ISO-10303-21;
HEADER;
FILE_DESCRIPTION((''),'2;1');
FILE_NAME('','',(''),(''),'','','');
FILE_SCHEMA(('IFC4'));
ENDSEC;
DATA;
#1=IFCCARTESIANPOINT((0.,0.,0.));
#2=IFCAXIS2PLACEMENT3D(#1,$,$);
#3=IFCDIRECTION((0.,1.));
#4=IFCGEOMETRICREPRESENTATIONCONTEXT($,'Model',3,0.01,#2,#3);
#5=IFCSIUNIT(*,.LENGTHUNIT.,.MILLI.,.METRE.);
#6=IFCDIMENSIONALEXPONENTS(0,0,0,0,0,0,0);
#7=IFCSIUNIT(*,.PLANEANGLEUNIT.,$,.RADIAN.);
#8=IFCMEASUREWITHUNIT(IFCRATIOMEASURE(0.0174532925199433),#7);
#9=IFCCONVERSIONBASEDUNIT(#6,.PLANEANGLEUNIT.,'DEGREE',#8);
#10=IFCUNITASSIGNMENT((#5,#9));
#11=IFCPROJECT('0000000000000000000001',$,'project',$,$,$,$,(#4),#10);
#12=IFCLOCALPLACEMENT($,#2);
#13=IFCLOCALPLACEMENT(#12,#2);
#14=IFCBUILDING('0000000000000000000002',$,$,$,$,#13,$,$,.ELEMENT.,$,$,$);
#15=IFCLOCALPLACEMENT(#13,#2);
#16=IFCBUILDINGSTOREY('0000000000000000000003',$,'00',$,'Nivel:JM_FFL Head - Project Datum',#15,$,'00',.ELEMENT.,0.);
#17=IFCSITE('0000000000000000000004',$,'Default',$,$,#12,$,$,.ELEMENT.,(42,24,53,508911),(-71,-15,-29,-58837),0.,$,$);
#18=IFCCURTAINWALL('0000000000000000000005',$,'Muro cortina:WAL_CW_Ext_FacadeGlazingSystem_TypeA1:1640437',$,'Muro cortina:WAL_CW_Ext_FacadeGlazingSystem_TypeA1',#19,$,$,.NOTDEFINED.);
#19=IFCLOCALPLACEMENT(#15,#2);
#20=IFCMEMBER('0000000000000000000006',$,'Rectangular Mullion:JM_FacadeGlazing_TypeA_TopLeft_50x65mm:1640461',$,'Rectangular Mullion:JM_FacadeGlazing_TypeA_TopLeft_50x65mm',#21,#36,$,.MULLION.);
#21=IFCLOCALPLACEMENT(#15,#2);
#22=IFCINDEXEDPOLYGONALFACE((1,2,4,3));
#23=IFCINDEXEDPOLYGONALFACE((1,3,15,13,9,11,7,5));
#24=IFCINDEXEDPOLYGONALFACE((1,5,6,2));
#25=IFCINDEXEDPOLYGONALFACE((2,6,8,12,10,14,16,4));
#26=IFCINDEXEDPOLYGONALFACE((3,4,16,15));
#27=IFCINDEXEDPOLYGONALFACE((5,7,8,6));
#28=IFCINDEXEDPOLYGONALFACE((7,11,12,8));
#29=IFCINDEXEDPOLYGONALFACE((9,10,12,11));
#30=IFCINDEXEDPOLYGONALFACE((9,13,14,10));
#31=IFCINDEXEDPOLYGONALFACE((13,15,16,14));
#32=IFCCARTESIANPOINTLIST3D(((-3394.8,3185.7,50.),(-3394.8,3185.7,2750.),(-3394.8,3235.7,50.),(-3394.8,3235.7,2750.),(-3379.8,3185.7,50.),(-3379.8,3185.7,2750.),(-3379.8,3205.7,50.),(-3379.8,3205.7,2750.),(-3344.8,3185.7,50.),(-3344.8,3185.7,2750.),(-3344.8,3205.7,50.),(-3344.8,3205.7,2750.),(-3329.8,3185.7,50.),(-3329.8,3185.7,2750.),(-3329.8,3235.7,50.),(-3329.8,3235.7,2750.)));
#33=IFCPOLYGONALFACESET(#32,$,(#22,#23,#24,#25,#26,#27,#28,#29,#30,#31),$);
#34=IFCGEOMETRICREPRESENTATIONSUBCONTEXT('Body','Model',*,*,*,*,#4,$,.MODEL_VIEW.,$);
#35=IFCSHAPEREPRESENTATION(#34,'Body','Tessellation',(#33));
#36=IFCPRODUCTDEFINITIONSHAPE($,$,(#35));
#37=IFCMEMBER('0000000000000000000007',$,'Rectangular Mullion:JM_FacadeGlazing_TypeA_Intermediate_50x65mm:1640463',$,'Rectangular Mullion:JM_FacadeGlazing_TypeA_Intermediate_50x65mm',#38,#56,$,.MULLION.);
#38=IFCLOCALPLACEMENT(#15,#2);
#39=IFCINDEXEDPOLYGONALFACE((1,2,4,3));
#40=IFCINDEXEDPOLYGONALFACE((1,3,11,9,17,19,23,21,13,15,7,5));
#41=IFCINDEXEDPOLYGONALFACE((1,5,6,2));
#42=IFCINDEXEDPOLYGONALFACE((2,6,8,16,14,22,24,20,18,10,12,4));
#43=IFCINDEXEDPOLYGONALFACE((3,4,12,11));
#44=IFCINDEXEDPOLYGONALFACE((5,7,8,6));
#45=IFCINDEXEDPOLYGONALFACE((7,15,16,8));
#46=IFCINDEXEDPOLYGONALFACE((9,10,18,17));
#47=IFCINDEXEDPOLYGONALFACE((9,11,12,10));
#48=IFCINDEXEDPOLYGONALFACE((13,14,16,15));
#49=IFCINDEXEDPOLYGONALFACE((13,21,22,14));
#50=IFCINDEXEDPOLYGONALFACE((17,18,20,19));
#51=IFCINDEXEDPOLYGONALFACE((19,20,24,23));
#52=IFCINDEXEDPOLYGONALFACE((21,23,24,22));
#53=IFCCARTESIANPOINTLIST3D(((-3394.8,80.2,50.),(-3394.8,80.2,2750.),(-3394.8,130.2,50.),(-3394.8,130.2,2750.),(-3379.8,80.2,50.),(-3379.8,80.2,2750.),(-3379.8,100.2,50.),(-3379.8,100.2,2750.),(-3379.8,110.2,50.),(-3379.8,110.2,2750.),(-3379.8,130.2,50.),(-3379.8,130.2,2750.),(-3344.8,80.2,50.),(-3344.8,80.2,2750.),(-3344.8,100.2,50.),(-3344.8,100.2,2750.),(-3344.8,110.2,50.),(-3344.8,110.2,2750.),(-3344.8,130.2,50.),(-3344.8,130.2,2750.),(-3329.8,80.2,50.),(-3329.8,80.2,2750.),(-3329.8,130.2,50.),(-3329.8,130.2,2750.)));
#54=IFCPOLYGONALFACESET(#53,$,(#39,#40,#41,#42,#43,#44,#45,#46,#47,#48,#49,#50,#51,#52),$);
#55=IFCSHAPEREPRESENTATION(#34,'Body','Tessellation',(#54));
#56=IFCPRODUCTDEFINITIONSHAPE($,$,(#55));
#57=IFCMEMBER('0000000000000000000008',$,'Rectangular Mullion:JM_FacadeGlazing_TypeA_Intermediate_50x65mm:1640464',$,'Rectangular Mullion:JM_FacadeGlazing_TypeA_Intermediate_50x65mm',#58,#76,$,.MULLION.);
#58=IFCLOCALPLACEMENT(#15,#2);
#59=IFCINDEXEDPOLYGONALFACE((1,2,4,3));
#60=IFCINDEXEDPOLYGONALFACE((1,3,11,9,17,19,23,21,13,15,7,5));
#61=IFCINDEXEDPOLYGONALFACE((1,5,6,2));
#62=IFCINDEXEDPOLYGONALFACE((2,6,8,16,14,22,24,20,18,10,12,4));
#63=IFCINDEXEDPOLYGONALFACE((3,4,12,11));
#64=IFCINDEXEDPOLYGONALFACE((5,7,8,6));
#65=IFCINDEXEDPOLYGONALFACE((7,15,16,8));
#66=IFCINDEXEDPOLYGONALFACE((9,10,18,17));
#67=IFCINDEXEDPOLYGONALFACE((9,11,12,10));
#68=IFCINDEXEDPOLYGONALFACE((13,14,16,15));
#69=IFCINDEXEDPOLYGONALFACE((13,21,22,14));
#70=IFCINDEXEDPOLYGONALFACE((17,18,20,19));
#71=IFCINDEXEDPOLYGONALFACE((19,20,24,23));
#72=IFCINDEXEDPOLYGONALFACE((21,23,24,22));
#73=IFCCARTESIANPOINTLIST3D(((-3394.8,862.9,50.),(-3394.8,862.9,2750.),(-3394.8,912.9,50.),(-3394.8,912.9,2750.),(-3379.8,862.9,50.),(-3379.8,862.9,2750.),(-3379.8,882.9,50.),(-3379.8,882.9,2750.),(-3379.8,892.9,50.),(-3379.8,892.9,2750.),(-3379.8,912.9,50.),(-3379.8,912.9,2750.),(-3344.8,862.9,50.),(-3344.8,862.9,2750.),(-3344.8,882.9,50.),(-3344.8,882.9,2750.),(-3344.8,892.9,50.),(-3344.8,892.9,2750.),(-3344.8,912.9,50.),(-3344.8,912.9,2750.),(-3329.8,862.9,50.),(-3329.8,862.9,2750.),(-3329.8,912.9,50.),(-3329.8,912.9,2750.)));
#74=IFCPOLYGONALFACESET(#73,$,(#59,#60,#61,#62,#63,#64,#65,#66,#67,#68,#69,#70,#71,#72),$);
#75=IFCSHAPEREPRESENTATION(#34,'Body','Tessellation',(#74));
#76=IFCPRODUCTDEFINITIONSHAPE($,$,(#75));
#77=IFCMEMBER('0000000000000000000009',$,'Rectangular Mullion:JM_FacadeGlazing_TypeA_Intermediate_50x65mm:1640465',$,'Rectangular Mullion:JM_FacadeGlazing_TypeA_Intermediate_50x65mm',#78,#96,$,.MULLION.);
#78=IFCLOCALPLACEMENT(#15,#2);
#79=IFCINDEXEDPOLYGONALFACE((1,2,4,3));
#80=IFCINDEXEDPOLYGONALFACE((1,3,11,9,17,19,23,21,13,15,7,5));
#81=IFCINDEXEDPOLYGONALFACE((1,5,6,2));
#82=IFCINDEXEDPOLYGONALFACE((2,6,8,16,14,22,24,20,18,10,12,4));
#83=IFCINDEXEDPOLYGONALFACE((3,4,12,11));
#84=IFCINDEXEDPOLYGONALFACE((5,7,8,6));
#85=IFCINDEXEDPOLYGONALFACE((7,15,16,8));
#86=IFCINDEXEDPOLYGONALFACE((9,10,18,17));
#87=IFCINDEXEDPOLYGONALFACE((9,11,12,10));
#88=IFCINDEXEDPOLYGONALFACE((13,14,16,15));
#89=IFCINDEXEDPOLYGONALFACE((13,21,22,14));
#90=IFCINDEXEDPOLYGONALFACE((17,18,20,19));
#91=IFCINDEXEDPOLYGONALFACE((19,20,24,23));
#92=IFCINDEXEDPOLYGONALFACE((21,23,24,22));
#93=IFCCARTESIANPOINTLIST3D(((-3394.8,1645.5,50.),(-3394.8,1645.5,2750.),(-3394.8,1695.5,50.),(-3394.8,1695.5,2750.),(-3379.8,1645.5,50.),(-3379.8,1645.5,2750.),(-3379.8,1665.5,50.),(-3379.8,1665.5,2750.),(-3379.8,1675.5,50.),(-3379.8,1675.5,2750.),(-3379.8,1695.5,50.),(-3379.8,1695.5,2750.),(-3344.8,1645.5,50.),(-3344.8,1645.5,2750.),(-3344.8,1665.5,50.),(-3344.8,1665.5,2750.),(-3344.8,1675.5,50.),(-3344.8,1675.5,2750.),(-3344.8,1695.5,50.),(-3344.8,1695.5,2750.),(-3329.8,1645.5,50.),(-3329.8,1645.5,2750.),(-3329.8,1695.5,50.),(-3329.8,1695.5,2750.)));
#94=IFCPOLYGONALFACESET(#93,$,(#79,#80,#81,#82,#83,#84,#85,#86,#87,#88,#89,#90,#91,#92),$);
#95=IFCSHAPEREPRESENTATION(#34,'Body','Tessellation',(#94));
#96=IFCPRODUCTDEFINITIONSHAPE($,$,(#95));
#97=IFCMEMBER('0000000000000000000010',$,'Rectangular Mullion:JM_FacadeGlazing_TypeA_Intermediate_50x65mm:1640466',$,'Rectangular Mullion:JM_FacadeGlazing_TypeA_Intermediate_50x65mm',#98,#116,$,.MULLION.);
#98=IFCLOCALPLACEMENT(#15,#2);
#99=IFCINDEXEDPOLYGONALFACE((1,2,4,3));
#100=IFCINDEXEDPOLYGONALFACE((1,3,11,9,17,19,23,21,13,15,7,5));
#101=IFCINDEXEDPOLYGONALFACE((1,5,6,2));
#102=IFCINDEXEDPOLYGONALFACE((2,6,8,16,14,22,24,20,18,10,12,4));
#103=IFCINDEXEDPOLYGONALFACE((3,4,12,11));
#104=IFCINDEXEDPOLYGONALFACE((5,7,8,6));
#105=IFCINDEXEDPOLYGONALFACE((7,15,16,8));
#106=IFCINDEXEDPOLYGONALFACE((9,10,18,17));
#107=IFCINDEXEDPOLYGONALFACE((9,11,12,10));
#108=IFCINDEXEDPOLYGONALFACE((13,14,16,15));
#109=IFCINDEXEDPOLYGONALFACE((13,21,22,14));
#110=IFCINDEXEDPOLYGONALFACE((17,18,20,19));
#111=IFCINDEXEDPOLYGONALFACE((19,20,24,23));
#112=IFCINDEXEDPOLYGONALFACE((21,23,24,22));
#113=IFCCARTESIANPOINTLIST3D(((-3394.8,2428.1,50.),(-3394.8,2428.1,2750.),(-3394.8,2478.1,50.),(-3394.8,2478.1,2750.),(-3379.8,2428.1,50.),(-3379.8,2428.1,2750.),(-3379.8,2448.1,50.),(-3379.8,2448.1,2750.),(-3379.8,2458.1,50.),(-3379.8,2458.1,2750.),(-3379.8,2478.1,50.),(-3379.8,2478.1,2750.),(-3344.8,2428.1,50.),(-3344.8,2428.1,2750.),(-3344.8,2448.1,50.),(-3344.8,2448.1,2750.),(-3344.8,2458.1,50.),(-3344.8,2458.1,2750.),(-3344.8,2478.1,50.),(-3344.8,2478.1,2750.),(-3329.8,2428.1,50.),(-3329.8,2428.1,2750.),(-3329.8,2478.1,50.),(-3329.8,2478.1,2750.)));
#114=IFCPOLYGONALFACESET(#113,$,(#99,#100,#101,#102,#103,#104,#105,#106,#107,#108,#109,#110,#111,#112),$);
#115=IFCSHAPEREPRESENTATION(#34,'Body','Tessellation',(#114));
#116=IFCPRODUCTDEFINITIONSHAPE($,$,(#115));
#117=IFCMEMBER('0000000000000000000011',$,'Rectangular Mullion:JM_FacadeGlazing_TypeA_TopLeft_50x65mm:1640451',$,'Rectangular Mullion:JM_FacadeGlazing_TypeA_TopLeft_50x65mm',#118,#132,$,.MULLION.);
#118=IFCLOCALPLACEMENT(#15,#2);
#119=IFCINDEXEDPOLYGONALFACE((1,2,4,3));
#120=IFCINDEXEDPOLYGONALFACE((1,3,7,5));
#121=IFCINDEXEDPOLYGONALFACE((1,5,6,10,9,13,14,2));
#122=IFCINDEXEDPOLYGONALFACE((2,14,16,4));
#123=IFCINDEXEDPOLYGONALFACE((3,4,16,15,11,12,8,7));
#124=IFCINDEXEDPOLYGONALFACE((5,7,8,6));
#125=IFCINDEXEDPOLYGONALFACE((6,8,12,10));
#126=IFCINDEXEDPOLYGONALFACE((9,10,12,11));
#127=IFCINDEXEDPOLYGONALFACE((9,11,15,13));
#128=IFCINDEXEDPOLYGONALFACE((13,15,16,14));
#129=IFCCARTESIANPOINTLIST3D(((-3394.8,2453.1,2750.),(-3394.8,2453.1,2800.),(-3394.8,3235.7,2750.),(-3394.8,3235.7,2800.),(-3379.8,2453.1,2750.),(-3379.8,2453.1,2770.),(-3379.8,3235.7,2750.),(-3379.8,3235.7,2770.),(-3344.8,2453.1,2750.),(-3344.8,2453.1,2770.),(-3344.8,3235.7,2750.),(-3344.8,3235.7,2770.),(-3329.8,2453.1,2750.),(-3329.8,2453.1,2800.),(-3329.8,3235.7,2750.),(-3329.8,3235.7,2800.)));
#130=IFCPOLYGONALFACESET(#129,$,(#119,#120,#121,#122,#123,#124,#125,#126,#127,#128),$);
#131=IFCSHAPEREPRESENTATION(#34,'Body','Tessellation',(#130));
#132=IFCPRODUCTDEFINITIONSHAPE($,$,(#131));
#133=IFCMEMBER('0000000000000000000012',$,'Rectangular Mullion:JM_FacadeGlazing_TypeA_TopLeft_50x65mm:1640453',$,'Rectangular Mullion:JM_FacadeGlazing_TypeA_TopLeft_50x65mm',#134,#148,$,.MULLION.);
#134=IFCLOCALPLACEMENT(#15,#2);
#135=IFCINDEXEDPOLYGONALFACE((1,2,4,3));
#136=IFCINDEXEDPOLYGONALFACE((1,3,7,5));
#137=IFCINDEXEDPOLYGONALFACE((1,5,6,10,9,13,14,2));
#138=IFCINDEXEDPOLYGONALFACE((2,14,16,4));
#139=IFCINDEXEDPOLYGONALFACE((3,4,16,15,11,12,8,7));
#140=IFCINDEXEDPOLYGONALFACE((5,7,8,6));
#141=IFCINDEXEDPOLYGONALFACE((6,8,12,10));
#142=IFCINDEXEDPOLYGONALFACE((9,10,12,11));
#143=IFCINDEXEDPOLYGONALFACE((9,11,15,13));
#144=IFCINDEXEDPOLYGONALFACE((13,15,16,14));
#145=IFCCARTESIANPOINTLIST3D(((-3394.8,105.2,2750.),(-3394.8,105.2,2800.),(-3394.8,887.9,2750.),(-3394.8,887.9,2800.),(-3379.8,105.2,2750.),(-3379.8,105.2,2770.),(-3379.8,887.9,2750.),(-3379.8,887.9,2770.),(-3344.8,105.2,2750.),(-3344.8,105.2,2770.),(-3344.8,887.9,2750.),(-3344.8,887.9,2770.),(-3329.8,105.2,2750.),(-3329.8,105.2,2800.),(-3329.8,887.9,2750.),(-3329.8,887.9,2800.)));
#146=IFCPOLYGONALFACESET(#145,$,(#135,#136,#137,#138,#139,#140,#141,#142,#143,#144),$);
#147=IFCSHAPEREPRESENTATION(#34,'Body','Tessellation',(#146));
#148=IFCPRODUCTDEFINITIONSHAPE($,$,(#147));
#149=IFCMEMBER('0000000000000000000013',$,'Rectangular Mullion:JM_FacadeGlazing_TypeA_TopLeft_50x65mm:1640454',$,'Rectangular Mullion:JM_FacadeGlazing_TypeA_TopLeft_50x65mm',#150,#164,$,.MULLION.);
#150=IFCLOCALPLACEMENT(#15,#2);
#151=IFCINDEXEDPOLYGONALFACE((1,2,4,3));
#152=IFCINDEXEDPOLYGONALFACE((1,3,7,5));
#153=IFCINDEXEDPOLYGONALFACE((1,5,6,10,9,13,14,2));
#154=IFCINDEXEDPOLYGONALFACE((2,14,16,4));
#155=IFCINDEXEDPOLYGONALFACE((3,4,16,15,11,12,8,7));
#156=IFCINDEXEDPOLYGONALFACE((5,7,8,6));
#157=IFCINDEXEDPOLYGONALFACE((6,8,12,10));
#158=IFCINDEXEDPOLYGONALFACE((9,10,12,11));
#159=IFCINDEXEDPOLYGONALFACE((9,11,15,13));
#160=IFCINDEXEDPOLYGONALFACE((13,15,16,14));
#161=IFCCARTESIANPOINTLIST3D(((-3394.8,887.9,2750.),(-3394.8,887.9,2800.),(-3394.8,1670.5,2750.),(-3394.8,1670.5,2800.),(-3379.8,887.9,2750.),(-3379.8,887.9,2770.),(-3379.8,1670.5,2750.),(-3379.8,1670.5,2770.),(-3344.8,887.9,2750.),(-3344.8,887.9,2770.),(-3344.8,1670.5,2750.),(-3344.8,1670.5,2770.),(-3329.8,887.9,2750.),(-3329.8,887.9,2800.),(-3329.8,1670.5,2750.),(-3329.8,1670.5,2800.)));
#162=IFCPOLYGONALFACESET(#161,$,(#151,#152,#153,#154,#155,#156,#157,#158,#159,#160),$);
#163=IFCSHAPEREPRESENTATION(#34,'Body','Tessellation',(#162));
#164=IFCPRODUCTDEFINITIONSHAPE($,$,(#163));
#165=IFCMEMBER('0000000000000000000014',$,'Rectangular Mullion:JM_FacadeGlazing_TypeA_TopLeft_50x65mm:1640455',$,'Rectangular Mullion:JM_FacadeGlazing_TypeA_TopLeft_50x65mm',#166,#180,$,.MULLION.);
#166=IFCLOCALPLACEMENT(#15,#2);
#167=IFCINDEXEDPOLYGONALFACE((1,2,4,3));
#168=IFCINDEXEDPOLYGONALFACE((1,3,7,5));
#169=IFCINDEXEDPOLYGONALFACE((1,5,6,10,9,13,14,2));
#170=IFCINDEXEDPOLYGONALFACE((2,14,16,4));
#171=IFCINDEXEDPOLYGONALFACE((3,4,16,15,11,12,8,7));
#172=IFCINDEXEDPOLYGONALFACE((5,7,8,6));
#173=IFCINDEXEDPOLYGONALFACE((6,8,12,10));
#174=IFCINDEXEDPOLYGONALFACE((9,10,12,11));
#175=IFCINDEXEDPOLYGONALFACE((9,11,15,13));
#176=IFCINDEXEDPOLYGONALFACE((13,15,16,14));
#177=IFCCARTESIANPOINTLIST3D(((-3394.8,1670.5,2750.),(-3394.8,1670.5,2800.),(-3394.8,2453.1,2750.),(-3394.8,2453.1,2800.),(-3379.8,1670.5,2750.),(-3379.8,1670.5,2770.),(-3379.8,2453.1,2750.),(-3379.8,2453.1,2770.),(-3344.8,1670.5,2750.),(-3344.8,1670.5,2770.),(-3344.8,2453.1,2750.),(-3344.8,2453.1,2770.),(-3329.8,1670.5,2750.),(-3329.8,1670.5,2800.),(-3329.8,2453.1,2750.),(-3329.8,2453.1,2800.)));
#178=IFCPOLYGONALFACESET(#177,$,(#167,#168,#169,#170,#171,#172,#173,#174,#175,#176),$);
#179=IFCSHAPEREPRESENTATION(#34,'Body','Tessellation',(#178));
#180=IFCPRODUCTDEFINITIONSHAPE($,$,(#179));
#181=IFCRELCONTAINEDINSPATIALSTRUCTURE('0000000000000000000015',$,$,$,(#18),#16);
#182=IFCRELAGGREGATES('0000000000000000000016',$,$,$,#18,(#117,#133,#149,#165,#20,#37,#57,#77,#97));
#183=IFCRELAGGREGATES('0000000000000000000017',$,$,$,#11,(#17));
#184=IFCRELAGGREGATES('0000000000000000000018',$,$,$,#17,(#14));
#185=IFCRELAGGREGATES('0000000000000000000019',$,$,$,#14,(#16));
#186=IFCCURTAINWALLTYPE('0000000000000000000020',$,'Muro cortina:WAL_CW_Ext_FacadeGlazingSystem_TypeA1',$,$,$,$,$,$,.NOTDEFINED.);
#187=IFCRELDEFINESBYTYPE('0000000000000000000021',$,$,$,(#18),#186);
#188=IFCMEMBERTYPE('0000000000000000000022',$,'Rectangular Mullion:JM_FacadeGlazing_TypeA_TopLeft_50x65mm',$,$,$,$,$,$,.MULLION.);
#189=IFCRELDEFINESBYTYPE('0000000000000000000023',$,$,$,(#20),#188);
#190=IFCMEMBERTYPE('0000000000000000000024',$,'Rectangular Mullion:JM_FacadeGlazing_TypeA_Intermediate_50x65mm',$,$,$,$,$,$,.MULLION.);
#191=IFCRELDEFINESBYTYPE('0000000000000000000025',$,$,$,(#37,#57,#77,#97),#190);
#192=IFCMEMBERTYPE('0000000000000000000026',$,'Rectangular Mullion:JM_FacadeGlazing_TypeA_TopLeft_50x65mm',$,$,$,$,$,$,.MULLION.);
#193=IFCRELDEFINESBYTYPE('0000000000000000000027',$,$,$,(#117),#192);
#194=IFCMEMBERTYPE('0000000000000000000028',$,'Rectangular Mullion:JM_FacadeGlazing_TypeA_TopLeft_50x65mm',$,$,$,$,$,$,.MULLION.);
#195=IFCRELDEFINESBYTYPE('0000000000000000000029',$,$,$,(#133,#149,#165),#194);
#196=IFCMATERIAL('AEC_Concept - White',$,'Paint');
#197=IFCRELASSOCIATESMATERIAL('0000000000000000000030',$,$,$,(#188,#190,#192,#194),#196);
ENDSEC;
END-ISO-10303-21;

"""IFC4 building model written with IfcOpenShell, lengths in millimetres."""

from ifc_helpers import new_model, entity, si_unit, converted_unit, direction, frame, origin, place, context, subcontext, project, spatial, indexed_curve, outline, extrude, source, transform, mapped, material, type_object, type_shapes, element, aggregate, save


model = new_model("IFC4")

# Units and contexts
model_context = context("Model", 3, precision=0.01, world=origin(), true_north=direction((0.0, 1.0)))
body_context = subcontext(model_context, "Body", "Model", "MODEL_VIEW")
ifc_project = project(units=[si_unit("LENGTHUNIT", "METRE", prefix="MILLI"), converted_unit("PLANEANGLEUNIT", "DEGREE", entity("IfcRatioMeasure", 0.0174532925199433), si_unit("PLANEANGLEUNIT", "RADIAN"), dimensions=[0, 0, 0, 0, 0, 0, 0])], contexts=[model_context])

# Site, building, storey
site_placement = place(None, origin())
site = spatial("IfcSite", under=ifc_project, at=site_placement, Name="Default", CompositionType="ELEMENT", RefLatitude=(42, 24, 53, 508911), RefLongitude=(-71, -15, -29, -58837), RefElevation=0.0)
building_placement = place(site_placement, origin())
building = spatial("IfcBuilding", under=site, at=building_placement, CompositionType="ELEMENT")
storey_placement = place(building_placement, origin())
storey = spatial("IfcBuildingStorey", under=building, at=storey_placement, Name="00", ObjectType="Nivel:JM_FFL Head - Project Datum", LongName="00", CompositionType="ELEMENT", Elevation=0.0)

# Curtain wall, members
curtain_wall_type = type_object("IfcCurtainWallType", Name="Muro cortina:WAL_CW_Ext_FacadeGlazingSystem_TypeA1", PredefinedType="NOTDEFINED")
curtain_wall_placement = place(storey_placement, origin())
curtain_wall = element("IfcCurtainWall", 1, at=curtain_wall_placement, inside=storey, type_object=curtain_wall_type, Name="Muro cortina:WAL_CW_Ext_FacadeGlazingSystem_TypeA1:1640437", ObjectType="Muro cortina:WAL_CW_Ext_FacadeGlazingSystem_TypeA1", PredefinedType="NOTDEFINED")
ifc_material_1 = material(Name="AEC_Concept - White", Category="Paint")
member_type_1 = type_object("IfcMemberType", Name="Rectangular Mullion:JM_FacadeGlazing_TypeA_TopLeft_50x65mm", PredefinedType="MULLION", material=ifc_material_1)
shared_shape_1 = source(origin(), body_context, "Body", "SweptSolid", [
    extrude(outline(indexed_curve([(-32.5, -17.5), (-17.5, -17.5), (-17.5, 2.5), (17.5, 2.5), (17.5, -17.5), (32.5, -17.5), (32.5, 32.5), (-32.5, 32.5), (-32.5, -17.5)], self_intersect=False)), frame((-32.5, -32.5, -2700.0), z_axis=(0.0, 0.0, 1.0), x_axis=(0.0, -1.0, 0.0)), (0.0, 0.0, 1.0), 2700.0),
])
type_shapes(member_type_1, [shared_shape_1])
member_1_placement = place(curtain_wall_placement, frame((-3329.8, 3235.7, 50.0), z_axis=(0.0, 0.0, -1.0), x_axis=(0.0, 1.0, 0.0)))
member_1 = element("IfcMember", 2, at=member_1_placement, type_object=member_type_1, Name="Rectangular Mullion:JM_FacadeGlazing_TypeA_TopLeft_50x65mm:1640461", ObjectType="Rectangular Mullion:JM_FacadeGlazing_TypeA_TopLeft_50x65mm", PredefinedType="MULLION", context=body_context, shape_type="MappedRepresentation", body=[
    mapped(shared_shape_1, transform((0.0, 0.0, 0.0), scale=1.0)),
])
member_type_2 = type_object("IfcMemberType", Name="Rectangular Mullion:JM_FacadeGlazing_TypeA_Intermediate_50x65mm", PredefinedType="MULLION", material=ifc_material_1)
shared_shape_2 = source(origin(), body_context, "Body", "SweptSolid", [
    extrude(outline(indexed_curve([(-32.5, -25.0), (-17.5, -25.0), (-17.5, -5.0), (17.5, -5.0), (17.5, -25.0), (32.5, -25.0), (32.5, 25.0), (17.5, 25.0), (17.5, 5.0), (-17.5, 5.0), (-17.5, 25.0), (-32.5, 25.0), (-32.5, -25.0)], self_intersect=False)), frame((0.0, -32.5, -2700.0), z_axis=(0.0, 0.0, 1.0), x_axis=(0.0, -1.0, 0.0)), (0.0, 0.0, 1.0), 2700.0),
])
type_shapes(member_type_2, [shared_shape_2])
member_2_placement = place(curtain_wall_placement, frame((-3329.8, 105.2, 50.0), z_axis=(0.0, 0.0, -1.0), x_axis=(0.0, 1.0, 0.0)))
member_2 = element("IfcMember", 3, at=member_2_placement, type_object=member_type_2, Name="Rectangular Mullion:JM_FacadeGlazing_TypeA_Intermediate_50x65mm:1640463", ObjectType="Rectangular Mullion:JM_FacadeGlazing_TypeA_Intermediate_50x65mm", PredefinedType="MULLION", context=body_context, shape_type="MappedRepresentation", body=[
    mapped(shared_shape_2, transform((0.0, 0.0, 0.0), scale=1.0)),
])
member_3_placement = place(curtain_wall_placement, frame((-3329.8, 887.9, 50.0), z_axis=(0.0, 0.0, -1.0), x_axis=(0.0, 1.0, 0.0)))
member_3 = element("IfcMember", 4, at=member_3_placement, type_object=member_type_2, Name="Rectangular Mullion:JM_FacadeGlazing_TypeA_Intermediate_50x65mm:1640464", ObjectType="Rectangular Mullion:JM_FacadeGlazing_TypeA_Intermediate_50x65mm", PredefinedType="MULLION", context=body_context, shape_type="MappedRepresentation", body=[
    mapped(shared_shape_2, transform((0.0, 0.0, 0.0), scale=1.0)),
])
member_4_placement = place(curtain_wall_placement, frame((-3329.8, 1670.5, 50.0), z_axis=(0.0, 0.0, -1.0), x_axis=(0.0, 1.0, 0.0)))
member_4 = element("IfcMember", 5, at=member_4_placement, type_object=member_type_2, Name="Rectangular Mullion:JM_FacadeGlazing_TypeA_Intermediate_50x65mm:1640465", ObjectType="Rectangular Mullion:JM_FacadeGlazing_TypeA_Intermediate_50x65mm", PredefinedType="MULLION", context=body_context, shape_type="MappedRepresentation", body=[
    mapped(shared_shape_2, transform((0.0, 0.0, 0.0), scale=1.0)),
])
member_5_placement = place(curtain_wall_placement, frame((-3329.8, 2453.1, 50.0), z_axis=(0.0, 0.0, -1.0), x_axis=(0.0, 1.0, 0.0)))
member_5 = element("IfcMember", 6, at=member_5_placement, type_object=member_type_2, Name="Rectangular Mullion:JM_FacadeGlazing_TypeA_Intermediate_50x65mm:1640466", ObjectType="Rectangular Mullion:JM_FacadeGlazing_TypeA_Intermediate_50x65mm", PredefinedType="MULLION", context=body_context, shape_type="MappedRepresentation", body=[
    mapped(shared_shape_2, transform((0.0, 0.0, 0.0), scale=1.0)),
])
member_type_3 = type_object("IfcMemberType", Name="Rectangular Mullion:JM_FacadeGlazing_TypeA_TopLeft_50x65mm", PredefinedType="MULLION", material=ifc_material_1)
shared_shape_3 = source(origin(), body_context, "Body", "SweptSolid", [
    extrude(outline(indexed_curve([(-32.5, -17.5), (-17.5, -17.5), (-17.5, 2.5), (17.5, 2.5), (17.5, -17.5), (32.5, -17.5), (32.5, 32.5), (-32.5, 32.5), (-32.5, -17.5)], self_intersect=False)), frame((-32.5, -32.5, -782.6), z_axis=(0.0, 0.0, 1.0), x_axis=(0.0, -1.0, 0.0)), (0.0, 0.0, 1.0), 782.6),
])
type_shapes(member_type_3, [shared_shape_3])
member_6_placement = place(curtain_wall_placement, frame((-3329.8, 3235.7, 2800.0), z_axis=(0.0, 1.0, 0.0), x_axis=(0.0, 0.0, 1.0)))
member_6 = element("IfcMember", 7, at=member_6_placement, type_object=member_type_3, Name="Rectangular Mullion:JM_FacadeGlazing_TypeA_TopLeft_50x65mm:1640451", ObjectType="Rectangular Mullion:JM_FacadeGlazing_TypeA_TopLeft_50x65mm", PredefinedType="MULLION", context=body_context, shape_type="MappedRepresentation", body=[
    mapped(shared_shape_3, transform((0.0, 0.0, 0.0), scale=1.0)),
])
member_type_4 = type_object("IfcMemberType", Name="Rectangular Mullion:JM_FacadeGlazing_TypeA_TopLeft_50x65mm", PredefinedType="MULLION", material=ifc_material_1)
shared_shape_4 = source(origin(), body_context, "Body", "SweptSolid", [
    extrude(outline(indexed_curve([(-32.5, -17.5), (-17.5, -17.5), (-17.5, 2.5), (17.5, 2.5), (17.5, -17.5), (32.5, -17.5), (32.5, 32.5), (-32.5, 32.5), (-32.5, -17.5)], self_intersect=False)), frame((-32.5, -32.5, -782.6), z_axis=(0.0, 0.0, 1.0), x_axis=(0.0, -1.0, 0.0)), (0.0, 0.0, 1.0), 782.6),
])
type_shapes(member_type_4, [shared_shape_4])
member_7_placement = place(curtain_wall_placement, frame((-3329.8, 887.9, 2800.0), z_axis=(0.0, 1.0, 0.0), x_axis=(0.0, 0.0, 1.0)))
member_7 = element("IfcMember", 8, at=member_7_placement, type_object=member_type_4, Name="Rectangular Mullion:JM_FacadeGlazing_TypeA_TopLeft_50x65mm:1640453", ObjectType="Rectangular Mullion:JM_FacadeGlazing_TypeA_TopLeft_50x65mm", PredefinedType="MULLION", context=body_context, shape_type="MappedRepresentation", body=[
    mapped(shared_shape_4, transform((0.0, 0.0, 0.0), scale=1.0)),
])
member_8_placement = place(curtain_wall_placement, frame((-3329.8, 1670.5, 2800.0), z_axis=(0.0, 1.0, 0.0), x_axis=(0.0, 0.0, 1.0)))
member_8 = element("IfcMember", 9, at=member_8_placement, type_object=member_type_4, Name="Rectangular Mullion:JM_FacadeGlazing_TypeA_TopLeft_50x65mm:1640454", ObjectType="Rectangular Mullion:JM_FacadeGlazing_TypeA_TopLeft_50x65mm", PredefinedType="MULLION", context=body_context, shape_type="MappedRepresentation", body=[
    mapped(shared_shape_4, transform((0.0, 0.0, 0.0), scale=1.0)),
])
member_9_placement = place(curtain_wall_placement, frame((-3329.8, 2453.1, 2800.0), z_axis=(0.0, 1.0, 0.0), x_axis=(0.0, 0.0, 1.0)))
member_9 = element("IfcMember", 10, at=member_9_placement, type_object=member_type_4, Name="Rectangular Mullion:JM_FacadeGlazing_TypeA_TopLeft_50x65mm:1640455", ObjectType="Rectangular Mullion:JM_FacadeGlazing_TypeA_TopLeft_50x65mm", PredefinedType="MULLION", context=body_context, shape_type="MappedRepresentation", body=[
    mapped(shared_shape_4, transform((0.0, 0.0, 0.0), scale=1.0)),
])
aggregate(curtain_wall, [member_6, member_7, member_8, member_9, member_1, member_2, member_3, member_4, member_5])

save(model, "model.ifc")
